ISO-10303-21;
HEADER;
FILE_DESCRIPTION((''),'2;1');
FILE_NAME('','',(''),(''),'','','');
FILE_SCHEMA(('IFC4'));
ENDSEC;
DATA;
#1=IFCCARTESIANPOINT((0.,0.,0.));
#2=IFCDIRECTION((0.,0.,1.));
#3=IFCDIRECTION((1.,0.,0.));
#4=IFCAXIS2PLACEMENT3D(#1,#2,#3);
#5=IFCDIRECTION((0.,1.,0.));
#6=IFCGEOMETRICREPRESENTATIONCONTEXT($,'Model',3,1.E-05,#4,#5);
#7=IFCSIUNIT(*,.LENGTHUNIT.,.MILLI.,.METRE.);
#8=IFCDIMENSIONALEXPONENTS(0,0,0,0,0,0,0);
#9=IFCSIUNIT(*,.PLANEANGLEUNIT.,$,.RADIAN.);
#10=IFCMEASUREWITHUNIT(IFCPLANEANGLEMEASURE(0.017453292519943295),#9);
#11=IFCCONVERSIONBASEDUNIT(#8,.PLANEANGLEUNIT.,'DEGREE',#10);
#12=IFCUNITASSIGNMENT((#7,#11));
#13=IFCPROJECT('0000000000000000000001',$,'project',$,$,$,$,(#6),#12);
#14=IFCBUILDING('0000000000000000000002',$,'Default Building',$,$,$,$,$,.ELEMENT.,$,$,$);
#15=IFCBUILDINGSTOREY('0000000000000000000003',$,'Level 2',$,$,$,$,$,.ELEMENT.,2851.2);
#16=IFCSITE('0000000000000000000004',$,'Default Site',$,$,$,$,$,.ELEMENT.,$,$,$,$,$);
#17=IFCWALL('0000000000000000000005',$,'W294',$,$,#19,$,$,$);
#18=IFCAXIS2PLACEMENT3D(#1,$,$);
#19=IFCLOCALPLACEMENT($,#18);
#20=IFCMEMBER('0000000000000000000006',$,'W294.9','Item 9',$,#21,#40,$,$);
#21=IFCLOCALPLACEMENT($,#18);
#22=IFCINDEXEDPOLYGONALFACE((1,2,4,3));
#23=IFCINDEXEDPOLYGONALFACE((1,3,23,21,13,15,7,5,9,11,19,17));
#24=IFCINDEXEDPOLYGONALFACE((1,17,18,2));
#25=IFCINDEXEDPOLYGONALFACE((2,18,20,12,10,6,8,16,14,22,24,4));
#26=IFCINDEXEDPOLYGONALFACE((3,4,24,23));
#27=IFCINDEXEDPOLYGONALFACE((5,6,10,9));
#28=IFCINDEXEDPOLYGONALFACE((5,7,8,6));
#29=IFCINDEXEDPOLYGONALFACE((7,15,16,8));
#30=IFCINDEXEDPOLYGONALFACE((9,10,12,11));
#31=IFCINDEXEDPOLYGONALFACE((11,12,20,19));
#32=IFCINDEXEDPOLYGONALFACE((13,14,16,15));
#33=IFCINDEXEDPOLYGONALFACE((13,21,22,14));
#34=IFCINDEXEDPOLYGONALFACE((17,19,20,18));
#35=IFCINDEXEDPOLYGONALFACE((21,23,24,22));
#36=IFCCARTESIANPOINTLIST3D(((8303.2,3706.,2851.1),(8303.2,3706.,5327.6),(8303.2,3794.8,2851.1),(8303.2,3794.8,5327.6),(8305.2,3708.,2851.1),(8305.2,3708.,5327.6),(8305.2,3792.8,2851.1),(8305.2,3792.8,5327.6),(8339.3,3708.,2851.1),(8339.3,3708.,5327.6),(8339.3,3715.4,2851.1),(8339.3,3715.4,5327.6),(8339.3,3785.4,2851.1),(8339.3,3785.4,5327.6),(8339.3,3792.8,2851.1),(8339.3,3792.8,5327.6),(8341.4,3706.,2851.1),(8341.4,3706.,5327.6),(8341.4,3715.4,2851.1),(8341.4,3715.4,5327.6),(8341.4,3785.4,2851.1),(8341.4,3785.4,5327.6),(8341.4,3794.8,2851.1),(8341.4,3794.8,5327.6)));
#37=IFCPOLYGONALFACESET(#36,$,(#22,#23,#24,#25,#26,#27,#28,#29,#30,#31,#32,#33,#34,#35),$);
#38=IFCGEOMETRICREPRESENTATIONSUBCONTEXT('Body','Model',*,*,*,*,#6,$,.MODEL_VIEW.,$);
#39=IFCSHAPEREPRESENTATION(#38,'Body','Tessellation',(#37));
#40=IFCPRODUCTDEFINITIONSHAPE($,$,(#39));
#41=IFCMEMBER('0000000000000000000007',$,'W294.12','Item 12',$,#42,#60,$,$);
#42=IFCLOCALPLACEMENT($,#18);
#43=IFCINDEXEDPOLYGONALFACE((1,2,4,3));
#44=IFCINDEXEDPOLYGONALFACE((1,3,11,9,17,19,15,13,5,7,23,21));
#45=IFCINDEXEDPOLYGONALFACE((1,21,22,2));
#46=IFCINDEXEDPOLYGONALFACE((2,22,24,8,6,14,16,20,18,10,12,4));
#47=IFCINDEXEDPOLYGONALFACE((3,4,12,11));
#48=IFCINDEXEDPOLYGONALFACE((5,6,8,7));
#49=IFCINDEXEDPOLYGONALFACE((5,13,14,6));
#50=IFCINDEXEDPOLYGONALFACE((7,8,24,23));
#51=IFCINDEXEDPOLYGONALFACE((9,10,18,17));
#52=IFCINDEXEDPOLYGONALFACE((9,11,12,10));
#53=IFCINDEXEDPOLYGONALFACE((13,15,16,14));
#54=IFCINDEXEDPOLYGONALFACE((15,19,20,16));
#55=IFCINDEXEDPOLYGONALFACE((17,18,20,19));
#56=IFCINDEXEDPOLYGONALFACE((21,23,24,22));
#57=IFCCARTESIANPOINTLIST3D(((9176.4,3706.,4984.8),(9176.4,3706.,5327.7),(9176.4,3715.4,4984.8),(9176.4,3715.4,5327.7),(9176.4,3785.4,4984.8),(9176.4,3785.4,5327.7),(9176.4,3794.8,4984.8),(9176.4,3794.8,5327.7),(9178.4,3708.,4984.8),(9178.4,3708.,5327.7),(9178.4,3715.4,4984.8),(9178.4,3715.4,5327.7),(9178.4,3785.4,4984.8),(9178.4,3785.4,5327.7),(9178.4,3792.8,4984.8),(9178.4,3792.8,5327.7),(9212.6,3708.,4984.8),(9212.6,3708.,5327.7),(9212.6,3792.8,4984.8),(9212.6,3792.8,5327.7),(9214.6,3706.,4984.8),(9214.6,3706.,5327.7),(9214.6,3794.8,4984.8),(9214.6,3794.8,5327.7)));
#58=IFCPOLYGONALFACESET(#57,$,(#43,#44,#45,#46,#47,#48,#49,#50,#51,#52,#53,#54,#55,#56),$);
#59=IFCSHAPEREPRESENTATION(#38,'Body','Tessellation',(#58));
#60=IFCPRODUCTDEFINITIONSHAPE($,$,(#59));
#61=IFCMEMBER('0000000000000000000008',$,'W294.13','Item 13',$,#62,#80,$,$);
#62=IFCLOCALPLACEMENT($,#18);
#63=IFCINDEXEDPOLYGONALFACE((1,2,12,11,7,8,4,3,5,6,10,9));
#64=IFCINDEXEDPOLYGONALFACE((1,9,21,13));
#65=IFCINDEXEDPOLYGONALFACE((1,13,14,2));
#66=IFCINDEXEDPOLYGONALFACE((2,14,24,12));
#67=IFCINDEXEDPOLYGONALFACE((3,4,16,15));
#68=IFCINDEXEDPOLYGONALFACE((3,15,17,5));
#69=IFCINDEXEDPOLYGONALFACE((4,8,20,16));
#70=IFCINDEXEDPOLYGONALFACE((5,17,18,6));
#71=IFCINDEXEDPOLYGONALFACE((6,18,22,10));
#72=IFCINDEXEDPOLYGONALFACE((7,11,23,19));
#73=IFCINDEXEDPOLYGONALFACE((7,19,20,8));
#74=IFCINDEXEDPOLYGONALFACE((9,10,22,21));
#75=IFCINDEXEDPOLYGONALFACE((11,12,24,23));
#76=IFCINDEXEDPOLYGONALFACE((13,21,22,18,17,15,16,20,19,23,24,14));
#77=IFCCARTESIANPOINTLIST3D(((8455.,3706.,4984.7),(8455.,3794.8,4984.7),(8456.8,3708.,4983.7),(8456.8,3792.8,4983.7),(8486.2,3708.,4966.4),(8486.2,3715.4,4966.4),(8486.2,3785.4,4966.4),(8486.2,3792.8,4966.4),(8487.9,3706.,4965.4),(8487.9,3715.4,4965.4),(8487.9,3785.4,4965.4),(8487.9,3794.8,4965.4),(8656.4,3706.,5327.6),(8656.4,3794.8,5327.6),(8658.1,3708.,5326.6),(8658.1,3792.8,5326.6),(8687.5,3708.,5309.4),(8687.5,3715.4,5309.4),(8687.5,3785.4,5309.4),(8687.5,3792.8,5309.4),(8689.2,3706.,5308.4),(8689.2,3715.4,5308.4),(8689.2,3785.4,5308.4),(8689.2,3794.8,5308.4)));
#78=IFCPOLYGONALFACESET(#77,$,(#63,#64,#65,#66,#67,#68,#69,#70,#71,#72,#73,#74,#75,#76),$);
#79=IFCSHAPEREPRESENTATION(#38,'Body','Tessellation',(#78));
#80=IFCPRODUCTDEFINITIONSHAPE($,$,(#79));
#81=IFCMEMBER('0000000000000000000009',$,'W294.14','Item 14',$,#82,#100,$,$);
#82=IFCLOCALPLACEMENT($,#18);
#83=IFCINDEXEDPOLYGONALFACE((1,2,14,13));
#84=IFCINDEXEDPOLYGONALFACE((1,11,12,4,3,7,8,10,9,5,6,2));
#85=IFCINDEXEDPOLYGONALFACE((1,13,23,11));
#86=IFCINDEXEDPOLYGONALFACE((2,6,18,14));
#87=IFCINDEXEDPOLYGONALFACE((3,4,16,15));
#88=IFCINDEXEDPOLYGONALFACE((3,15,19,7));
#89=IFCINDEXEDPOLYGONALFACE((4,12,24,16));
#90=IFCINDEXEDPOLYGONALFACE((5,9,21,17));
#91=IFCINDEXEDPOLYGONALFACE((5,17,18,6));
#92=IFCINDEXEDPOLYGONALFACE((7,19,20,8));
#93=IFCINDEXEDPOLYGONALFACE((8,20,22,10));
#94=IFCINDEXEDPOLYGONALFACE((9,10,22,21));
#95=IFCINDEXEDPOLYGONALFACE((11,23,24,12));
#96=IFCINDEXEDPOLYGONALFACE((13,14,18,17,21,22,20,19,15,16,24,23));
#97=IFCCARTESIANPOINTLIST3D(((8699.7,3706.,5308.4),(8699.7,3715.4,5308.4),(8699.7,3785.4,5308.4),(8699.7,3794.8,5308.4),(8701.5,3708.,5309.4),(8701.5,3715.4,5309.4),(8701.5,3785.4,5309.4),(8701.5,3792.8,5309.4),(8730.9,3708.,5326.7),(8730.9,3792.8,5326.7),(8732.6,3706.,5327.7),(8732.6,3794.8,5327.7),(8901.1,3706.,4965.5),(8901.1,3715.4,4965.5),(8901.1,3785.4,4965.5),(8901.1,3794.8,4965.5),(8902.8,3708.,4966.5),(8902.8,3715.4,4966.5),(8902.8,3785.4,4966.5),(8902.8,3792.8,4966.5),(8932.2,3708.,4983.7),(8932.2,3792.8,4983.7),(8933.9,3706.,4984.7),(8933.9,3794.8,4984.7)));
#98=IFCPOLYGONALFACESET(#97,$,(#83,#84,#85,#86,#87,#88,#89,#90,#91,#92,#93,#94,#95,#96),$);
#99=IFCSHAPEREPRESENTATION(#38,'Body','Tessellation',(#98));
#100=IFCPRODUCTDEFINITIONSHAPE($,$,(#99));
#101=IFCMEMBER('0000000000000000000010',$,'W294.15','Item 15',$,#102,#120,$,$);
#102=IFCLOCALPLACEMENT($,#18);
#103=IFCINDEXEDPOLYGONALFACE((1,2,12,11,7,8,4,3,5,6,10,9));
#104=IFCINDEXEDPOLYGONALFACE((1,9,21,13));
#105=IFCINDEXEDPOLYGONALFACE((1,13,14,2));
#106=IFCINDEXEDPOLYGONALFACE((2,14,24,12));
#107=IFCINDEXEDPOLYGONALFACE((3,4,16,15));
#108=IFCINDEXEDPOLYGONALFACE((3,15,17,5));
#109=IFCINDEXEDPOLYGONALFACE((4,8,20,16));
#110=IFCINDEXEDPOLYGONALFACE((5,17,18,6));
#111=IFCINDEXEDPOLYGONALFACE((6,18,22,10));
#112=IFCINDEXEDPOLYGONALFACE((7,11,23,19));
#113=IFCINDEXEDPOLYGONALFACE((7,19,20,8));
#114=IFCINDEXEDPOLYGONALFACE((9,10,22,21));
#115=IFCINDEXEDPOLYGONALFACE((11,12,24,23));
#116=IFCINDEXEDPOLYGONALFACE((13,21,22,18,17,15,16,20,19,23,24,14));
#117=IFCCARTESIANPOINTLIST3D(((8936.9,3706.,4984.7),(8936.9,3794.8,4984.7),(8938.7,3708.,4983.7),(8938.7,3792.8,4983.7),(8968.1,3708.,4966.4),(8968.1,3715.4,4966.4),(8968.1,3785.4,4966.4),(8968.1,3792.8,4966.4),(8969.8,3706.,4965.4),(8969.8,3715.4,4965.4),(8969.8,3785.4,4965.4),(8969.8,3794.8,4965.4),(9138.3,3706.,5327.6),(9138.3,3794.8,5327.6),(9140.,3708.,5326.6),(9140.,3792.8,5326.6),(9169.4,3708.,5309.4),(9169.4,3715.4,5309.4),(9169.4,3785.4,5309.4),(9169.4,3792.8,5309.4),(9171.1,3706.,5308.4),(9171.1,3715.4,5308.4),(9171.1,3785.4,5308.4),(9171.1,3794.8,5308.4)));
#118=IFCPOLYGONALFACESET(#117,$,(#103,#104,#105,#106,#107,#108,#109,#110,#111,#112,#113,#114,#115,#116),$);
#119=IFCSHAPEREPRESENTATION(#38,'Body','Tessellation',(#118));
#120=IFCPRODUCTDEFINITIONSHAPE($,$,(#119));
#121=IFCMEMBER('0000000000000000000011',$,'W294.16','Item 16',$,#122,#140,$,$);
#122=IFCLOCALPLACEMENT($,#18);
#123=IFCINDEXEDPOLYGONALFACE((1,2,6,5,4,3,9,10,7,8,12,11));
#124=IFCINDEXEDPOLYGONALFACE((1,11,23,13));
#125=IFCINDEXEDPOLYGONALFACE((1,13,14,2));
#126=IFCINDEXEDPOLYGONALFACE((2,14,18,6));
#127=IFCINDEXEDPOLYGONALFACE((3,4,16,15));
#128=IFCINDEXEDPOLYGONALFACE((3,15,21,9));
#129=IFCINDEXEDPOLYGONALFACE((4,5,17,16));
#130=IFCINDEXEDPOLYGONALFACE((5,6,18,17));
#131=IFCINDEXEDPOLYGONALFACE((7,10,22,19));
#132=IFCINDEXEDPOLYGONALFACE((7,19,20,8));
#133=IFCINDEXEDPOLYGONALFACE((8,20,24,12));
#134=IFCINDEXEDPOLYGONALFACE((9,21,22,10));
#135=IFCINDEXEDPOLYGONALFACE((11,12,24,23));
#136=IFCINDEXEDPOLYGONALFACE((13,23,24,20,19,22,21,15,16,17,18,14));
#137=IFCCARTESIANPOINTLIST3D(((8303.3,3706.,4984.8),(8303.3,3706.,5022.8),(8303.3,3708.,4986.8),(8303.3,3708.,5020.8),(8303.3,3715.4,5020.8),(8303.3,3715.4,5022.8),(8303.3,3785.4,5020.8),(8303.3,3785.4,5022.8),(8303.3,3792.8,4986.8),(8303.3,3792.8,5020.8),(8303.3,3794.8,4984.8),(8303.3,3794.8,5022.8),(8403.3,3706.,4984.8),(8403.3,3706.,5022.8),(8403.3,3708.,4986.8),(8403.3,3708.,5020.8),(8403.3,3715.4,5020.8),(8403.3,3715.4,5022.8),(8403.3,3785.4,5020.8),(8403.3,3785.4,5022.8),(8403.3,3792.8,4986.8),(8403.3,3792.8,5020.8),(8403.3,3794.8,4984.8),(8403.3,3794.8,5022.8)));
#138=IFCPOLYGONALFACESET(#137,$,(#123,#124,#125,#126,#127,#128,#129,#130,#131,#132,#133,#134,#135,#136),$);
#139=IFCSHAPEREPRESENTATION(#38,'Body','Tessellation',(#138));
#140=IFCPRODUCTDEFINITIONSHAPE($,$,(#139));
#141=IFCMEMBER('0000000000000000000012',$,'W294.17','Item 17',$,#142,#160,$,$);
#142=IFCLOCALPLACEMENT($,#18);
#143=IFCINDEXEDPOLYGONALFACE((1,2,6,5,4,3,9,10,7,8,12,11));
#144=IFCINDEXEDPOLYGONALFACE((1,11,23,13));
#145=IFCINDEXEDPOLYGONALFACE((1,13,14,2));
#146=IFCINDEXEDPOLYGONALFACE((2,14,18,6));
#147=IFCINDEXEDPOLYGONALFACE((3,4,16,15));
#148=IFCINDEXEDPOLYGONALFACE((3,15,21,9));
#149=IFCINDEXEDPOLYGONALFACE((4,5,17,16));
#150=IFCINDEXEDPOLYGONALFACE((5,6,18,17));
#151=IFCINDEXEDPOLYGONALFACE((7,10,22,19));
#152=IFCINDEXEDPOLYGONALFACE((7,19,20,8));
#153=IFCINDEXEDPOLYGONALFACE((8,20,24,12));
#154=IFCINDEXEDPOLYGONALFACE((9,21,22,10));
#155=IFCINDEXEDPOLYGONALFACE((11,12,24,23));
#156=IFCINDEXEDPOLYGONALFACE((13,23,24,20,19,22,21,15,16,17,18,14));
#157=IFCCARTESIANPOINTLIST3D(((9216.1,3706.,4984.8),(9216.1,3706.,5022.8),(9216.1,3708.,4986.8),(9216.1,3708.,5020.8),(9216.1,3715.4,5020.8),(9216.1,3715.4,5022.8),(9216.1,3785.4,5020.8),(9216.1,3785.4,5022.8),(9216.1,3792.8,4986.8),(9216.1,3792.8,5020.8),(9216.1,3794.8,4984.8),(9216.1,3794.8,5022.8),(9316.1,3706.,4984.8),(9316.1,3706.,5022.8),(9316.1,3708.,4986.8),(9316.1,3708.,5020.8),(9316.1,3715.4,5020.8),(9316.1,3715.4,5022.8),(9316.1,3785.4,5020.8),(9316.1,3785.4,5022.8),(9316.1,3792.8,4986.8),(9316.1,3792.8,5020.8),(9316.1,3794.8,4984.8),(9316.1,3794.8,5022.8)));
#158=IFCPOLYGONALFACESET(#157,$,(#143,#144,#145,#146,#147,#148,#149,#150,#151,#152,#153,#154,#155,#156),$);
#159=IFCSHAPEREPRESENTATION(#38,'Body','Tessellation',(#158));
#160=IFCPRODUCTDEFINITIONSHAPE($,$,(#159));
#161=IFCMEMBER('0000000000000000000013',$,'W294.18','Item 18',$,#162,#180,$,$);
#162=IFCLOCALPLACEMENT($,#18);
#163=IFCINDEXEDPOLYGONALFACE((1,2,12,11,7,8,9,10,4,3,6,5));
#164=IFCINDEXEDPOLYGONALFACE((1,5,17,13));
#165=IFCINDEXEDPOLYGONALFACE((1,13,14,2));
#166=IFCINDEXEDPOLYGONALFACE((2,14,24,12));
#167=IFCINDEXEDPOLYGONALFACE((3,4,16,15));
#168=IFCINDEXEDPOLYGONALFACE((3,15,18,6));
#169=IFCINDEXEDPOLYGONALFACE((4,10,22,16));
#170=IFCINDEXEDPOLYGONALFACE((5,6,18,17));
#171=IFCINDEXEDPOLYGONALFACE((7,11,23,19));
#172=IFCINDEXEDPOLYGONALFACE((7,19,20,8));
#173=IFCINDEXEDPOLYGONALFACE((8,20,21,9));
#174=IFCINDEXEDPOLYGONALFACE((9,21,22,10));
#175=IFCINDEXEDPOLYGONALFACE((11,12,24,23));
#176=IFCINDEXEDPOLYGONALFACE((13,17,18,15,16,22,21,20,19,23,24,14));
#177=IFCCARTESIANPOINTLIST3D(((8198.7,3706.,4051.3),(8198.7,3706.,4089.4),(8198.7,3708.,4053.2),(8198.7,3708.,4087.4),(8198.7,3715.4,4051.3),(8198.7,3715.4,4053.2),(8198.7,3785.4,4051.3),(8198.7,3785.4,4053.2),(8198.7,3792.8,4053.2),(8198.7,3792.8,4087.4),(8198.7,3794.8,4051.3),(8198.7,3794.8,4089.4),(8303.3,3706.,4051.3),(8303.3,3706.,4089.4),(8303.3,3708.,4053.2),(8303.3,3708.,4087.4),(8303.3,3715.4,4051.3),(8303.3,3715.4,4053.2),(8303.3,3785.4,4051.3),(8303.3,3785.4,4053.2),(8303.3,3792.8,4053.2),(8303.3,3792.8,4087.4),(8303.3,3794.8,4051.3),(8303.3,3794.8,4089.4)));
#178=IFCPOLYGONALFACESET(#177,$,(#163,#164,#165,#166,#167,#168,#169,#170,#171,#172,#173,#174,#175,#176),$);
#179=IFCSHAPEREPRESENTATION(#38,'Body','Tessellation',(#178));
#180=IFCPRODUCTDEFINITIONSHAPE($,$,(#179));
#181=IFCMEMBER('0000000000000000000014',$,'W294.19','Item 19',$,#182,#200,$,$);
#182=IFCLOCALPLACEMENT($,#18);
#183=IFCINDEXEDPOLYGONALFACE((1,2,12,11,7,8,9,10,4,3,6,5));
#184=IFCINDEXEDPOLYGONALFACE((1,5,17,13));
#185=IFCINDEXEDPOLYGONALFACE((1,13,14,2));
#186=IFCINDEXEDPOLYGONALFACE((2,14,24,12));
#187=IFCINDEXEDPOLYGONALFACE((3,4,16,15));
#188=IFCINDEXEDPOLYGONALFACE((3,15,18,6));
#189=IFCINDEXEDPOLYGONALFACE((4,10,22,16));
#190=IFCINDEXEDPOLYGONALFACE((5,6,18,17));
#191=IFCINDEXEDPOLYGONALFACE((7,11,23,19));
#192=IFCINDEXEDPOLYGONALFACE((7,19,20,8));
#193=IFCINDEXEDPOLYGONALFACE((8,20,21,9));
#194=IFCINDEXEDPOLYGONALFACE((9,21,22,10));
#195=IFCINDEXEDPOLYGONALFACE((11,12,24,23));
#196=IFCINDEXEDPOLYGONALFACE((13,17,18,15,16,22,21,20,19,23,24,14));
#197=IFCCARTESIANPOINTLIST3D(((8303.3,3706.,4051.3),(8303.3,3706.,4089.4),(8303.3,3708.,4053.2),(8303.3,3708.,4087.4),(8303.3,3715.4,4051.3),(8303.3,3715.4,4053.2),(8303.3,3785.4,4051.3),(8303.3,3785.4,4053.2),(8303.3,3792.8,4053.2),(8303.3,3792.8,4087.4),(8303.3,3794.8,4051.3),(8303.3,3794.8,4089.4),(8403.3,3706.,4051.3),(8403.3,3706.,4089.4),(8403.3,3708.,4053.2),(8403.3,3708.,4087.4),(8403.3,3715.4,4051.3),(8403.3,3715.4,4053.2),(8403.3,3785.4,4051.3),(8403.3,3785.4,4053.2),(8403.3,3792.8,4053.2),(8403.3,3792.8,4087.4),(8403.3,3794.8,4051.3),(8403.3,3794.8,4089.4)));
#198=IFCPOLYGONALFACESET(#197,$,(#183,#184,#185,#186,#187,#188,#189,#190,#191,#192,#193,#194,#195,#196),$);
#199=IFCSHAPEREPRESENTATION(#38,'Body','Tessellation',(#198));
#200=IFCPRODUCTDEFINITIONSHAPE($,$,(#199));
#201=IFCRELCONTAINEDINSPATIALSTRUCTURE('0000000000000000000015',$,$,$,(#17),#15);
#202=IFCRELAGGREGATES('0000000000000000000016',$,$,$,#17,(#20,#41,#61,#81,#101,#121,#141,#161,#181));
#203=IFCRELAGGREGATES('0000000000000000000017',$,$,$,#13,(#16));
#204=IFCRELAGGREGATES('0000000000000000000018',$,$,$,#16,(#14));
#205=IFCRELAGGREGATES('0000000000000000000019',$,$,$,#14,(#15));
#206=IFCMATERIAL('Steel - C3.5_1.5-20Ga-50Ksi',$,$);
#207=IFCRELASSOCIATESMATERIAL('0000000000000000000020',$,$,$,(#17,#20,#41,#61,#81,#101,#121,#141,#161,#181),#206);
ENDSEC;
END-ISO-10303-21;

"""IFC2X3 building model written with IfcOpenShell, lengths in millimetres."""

from ifc_helpers import new_model, entity, si_unit, converted_unit, direction, frame, origin, origin_with_axes, origin_2d_with_axis, place, context, subcontext, project, spatial, c_section, extrude, material, element, aggregate, save


model = new_model("IFC2X3")

# Units and contexts
model_context = context("Model", 3, precision=1e-05, world=origin_with_axes(), true_north=direction((0.0, 1.0, 0.0)))
body_context = subcontext(model_context, "Body", "Model", "MODEL_VIEW")
ifc_project = project(units=[si_unit("LENGTHUNIT", "METRE", prefix="MILLI"), converted_unit("PLANEANGLEUNIT", "DEGREE", entity("IfcPlaneAngleMeasure", 0.017453292519943295), si_unit("PLANEANGLEUNIT", "RADIAN"), dimensions=[0, 0, 0, 0, 0, 0, 0])], contexts=[model_context])

# Site, building, storey
site = spatial("IfcSite", under=ifc_project, Name="Default Site", CompositionType="ELEMENT")
building = spatial("IfcBuilding", under=site, Name="Default Building", CompositionType="ELEMENT")
storey = spatial("IfcBuildingStorey", under=building, Name="Level 2", CompositionType="ELEMENT", Elevation=2851.2)

# Shared definitions
ifc_material_1 = material(Name="Steel - C3.5_1.5-20Ga-50Ksi")

# Wall, members
wall_1 = element("IfcWall", 1, inside=storey, material=ifc_material_1, Name="W294")
member_1_placement = place(None, frame((8322.3, 3750.4, 5327.6), z_axis=(0.0, 0.0, -1.0), x_axis=(1.0, 0.0, 0.0)))
member_1 = element("IfcMember", 2, at=member_1_placement, material=ifc_material_1, Name="W294.9", Description="Item 9", context=body_context, shape_type="SweptSolid", body=[
    extrude(c_section(Depth=88.9, Width=38.1, WallThickness=2.0, Girth=9.5, at=origin_2d_with_axis()), origin(), (0.0, 0.0, 1.0), 2476.5),
])
member_2_placement = place(None, frame((9195.5, 3750.4, 4984.8), z_axis=(0.0, 0.0, 1.0), x_axis=(-1.0, 0.0, 0.0)))
member_2 = element("IfcMember", 3, at=member_2_placement, material=ifc_material_1, Name="W294.12", Description="Item 12", context=body_context, shape_type="SweptSolid", body=[
    extrude(c_section(Depth=88.9, Width=38.1, WallThickness=2.0, Girth=9.5, at=origin_2d_with_axis()), origin(), (0.0, 0.0, 1.0), 342.9),
])
member_3_placement = place(None, frame((8672.8, 3750.4, 5318.0), z_axis=(-0.506, 0.0, -0.862), x_axis=(0.862, 0.0, -0.506)))
member_3 = element("IfcMember", 4, at=member_3_placement, material=ifc_material_1, Name="W294.13", Description="Item 13", context=body_context, shape_type="SweptSolid", body=[
    extrude(c_section(Depth=88.9, Width=38.1, WallThickness=2.0, Girth=9.5, at=origin_2d_with_axis()), origin(), (0.0, 0.0, 1.0), 397.7),
])
member_4_placement = place(None, frame((8917.5, 3750.4, 4975.1), z_axis=(-0.506, 0.0, 0.862), x_axis=(-0.862, 0.0, -0.506)))
member_4 = element("IfcMember", 5, at=member_4_placement, material=ifc_material_1, Name="W294.14", Description="Item 14", context=body_context, shape_type="SweptSolid", body=[
    extrude(c_section(Depth=88.9, Width=38.1, WallThickness=2.0, Girth=9.5, at=origin_2d_with_axis()), origin(), (0.0, 0.0, 1.0), 397.7),
])
member_5_placement = place(None, frame((9154.7, 3750.4, 5318.0), z_axis=(-0.506, 0.0, -0.862), x_axis=(0.862, 0.0, -0.506)))
member_5 = element("IfcMember", 6, at=member_5_placement, material=ifc_material_1, Name="W294.15", Description="Item 15", context=body_context, shape_type="SweptSolid", body=[
    extrude(c_section(Depth=88.9, Width=38.1, WallThickness=2.0, Girth=9.5, at=origin_2d_with_axis()), origin(), (0.0, 0.0, 1.0), 397.7),
])
member_6_placement = place(None, frame((8303.3, 3750.4, 5003.8), z_axis=(1.0, 0.0, 0.0), x_axis=(0.0, 0.0, 1.0)))
member_6 = element("IfcMember", 7, at=member_6_placement, material=ifc_material_1, Name="W294.16", Description="Item 16", context=body_context, shape_type="SweptSolid", body=[
    extrude(c_section(Depth=88.9, Width=38.1, WallThickness=2.0, Girth=9.5, at=origin_2d_with_axis()), origin(), (0.0, 0.0, 1.0), 100.0),
])
member_7_placement = place(None, frame((9216.1, 3750.4, 5003.8), z_axis=(1.0, 0.0, 0.0), x_axis=(0.0, 0.0, 1.0)))
member_7 = element("IfcMember", 8, at=member_7_placement, material=ifc_material_1, Name="W294.17", Description="Item 17", context=body_context, shape_type="SweptSolid", body=[
    extrude(c_section(Depth=88.9, Width=38.1, WallThickness=2.0, Girth=9.5, at=origin_2d_with_axis()), origin(), (0.0, 0.0, 1.0), 100.0),
])
member_8_placement = place(None, frame((8303.3, 3750.4, 4070.3), z_axis=(-1.0, 0.0, 0.0), x_axis=(0.0, 0.0, -1.0)))
member_8 = element("IfcMember", 9, at=member_8_placement, material=ifc_material_1, Name="W294.18", Description="Item 18", context=body_context, shape_type="SweptSolid", body=[
    extrude(c_section(Depth=88.9, Width=38.1, WallThickness=2.0, Girth=9.5, at=origin_2d_with_axis()), origin(), (0.0, 0.0, 1.0), 104.6),
])
member_9_placement = place(None, frame((8403.3, 3750.4, 4070.3), z_axis=(-1.0, 0.0, 0.0), x_axis=(0.0, 0.0, -1.0)))
member_9 = element("IfcMember", 10, at=member_9_placement, material=ifc_material_1, Name="W294.19", Description="Item 19", context=body_context, shape_type="SweptSolid", body=[
    extrude(c_section(Depth=88.9, Width=38.1, WallThickness=2.0, Girth=9.5, at=origin_2d_with_axis()), origin(), (0.0, 0.0, 1.0), 100.0),
])
aggregate(wall_1, [member_1, member_2, member_3, member_4, member_5, member_6, member_7, member_8, member_9])

save(model, "model.ifc")
